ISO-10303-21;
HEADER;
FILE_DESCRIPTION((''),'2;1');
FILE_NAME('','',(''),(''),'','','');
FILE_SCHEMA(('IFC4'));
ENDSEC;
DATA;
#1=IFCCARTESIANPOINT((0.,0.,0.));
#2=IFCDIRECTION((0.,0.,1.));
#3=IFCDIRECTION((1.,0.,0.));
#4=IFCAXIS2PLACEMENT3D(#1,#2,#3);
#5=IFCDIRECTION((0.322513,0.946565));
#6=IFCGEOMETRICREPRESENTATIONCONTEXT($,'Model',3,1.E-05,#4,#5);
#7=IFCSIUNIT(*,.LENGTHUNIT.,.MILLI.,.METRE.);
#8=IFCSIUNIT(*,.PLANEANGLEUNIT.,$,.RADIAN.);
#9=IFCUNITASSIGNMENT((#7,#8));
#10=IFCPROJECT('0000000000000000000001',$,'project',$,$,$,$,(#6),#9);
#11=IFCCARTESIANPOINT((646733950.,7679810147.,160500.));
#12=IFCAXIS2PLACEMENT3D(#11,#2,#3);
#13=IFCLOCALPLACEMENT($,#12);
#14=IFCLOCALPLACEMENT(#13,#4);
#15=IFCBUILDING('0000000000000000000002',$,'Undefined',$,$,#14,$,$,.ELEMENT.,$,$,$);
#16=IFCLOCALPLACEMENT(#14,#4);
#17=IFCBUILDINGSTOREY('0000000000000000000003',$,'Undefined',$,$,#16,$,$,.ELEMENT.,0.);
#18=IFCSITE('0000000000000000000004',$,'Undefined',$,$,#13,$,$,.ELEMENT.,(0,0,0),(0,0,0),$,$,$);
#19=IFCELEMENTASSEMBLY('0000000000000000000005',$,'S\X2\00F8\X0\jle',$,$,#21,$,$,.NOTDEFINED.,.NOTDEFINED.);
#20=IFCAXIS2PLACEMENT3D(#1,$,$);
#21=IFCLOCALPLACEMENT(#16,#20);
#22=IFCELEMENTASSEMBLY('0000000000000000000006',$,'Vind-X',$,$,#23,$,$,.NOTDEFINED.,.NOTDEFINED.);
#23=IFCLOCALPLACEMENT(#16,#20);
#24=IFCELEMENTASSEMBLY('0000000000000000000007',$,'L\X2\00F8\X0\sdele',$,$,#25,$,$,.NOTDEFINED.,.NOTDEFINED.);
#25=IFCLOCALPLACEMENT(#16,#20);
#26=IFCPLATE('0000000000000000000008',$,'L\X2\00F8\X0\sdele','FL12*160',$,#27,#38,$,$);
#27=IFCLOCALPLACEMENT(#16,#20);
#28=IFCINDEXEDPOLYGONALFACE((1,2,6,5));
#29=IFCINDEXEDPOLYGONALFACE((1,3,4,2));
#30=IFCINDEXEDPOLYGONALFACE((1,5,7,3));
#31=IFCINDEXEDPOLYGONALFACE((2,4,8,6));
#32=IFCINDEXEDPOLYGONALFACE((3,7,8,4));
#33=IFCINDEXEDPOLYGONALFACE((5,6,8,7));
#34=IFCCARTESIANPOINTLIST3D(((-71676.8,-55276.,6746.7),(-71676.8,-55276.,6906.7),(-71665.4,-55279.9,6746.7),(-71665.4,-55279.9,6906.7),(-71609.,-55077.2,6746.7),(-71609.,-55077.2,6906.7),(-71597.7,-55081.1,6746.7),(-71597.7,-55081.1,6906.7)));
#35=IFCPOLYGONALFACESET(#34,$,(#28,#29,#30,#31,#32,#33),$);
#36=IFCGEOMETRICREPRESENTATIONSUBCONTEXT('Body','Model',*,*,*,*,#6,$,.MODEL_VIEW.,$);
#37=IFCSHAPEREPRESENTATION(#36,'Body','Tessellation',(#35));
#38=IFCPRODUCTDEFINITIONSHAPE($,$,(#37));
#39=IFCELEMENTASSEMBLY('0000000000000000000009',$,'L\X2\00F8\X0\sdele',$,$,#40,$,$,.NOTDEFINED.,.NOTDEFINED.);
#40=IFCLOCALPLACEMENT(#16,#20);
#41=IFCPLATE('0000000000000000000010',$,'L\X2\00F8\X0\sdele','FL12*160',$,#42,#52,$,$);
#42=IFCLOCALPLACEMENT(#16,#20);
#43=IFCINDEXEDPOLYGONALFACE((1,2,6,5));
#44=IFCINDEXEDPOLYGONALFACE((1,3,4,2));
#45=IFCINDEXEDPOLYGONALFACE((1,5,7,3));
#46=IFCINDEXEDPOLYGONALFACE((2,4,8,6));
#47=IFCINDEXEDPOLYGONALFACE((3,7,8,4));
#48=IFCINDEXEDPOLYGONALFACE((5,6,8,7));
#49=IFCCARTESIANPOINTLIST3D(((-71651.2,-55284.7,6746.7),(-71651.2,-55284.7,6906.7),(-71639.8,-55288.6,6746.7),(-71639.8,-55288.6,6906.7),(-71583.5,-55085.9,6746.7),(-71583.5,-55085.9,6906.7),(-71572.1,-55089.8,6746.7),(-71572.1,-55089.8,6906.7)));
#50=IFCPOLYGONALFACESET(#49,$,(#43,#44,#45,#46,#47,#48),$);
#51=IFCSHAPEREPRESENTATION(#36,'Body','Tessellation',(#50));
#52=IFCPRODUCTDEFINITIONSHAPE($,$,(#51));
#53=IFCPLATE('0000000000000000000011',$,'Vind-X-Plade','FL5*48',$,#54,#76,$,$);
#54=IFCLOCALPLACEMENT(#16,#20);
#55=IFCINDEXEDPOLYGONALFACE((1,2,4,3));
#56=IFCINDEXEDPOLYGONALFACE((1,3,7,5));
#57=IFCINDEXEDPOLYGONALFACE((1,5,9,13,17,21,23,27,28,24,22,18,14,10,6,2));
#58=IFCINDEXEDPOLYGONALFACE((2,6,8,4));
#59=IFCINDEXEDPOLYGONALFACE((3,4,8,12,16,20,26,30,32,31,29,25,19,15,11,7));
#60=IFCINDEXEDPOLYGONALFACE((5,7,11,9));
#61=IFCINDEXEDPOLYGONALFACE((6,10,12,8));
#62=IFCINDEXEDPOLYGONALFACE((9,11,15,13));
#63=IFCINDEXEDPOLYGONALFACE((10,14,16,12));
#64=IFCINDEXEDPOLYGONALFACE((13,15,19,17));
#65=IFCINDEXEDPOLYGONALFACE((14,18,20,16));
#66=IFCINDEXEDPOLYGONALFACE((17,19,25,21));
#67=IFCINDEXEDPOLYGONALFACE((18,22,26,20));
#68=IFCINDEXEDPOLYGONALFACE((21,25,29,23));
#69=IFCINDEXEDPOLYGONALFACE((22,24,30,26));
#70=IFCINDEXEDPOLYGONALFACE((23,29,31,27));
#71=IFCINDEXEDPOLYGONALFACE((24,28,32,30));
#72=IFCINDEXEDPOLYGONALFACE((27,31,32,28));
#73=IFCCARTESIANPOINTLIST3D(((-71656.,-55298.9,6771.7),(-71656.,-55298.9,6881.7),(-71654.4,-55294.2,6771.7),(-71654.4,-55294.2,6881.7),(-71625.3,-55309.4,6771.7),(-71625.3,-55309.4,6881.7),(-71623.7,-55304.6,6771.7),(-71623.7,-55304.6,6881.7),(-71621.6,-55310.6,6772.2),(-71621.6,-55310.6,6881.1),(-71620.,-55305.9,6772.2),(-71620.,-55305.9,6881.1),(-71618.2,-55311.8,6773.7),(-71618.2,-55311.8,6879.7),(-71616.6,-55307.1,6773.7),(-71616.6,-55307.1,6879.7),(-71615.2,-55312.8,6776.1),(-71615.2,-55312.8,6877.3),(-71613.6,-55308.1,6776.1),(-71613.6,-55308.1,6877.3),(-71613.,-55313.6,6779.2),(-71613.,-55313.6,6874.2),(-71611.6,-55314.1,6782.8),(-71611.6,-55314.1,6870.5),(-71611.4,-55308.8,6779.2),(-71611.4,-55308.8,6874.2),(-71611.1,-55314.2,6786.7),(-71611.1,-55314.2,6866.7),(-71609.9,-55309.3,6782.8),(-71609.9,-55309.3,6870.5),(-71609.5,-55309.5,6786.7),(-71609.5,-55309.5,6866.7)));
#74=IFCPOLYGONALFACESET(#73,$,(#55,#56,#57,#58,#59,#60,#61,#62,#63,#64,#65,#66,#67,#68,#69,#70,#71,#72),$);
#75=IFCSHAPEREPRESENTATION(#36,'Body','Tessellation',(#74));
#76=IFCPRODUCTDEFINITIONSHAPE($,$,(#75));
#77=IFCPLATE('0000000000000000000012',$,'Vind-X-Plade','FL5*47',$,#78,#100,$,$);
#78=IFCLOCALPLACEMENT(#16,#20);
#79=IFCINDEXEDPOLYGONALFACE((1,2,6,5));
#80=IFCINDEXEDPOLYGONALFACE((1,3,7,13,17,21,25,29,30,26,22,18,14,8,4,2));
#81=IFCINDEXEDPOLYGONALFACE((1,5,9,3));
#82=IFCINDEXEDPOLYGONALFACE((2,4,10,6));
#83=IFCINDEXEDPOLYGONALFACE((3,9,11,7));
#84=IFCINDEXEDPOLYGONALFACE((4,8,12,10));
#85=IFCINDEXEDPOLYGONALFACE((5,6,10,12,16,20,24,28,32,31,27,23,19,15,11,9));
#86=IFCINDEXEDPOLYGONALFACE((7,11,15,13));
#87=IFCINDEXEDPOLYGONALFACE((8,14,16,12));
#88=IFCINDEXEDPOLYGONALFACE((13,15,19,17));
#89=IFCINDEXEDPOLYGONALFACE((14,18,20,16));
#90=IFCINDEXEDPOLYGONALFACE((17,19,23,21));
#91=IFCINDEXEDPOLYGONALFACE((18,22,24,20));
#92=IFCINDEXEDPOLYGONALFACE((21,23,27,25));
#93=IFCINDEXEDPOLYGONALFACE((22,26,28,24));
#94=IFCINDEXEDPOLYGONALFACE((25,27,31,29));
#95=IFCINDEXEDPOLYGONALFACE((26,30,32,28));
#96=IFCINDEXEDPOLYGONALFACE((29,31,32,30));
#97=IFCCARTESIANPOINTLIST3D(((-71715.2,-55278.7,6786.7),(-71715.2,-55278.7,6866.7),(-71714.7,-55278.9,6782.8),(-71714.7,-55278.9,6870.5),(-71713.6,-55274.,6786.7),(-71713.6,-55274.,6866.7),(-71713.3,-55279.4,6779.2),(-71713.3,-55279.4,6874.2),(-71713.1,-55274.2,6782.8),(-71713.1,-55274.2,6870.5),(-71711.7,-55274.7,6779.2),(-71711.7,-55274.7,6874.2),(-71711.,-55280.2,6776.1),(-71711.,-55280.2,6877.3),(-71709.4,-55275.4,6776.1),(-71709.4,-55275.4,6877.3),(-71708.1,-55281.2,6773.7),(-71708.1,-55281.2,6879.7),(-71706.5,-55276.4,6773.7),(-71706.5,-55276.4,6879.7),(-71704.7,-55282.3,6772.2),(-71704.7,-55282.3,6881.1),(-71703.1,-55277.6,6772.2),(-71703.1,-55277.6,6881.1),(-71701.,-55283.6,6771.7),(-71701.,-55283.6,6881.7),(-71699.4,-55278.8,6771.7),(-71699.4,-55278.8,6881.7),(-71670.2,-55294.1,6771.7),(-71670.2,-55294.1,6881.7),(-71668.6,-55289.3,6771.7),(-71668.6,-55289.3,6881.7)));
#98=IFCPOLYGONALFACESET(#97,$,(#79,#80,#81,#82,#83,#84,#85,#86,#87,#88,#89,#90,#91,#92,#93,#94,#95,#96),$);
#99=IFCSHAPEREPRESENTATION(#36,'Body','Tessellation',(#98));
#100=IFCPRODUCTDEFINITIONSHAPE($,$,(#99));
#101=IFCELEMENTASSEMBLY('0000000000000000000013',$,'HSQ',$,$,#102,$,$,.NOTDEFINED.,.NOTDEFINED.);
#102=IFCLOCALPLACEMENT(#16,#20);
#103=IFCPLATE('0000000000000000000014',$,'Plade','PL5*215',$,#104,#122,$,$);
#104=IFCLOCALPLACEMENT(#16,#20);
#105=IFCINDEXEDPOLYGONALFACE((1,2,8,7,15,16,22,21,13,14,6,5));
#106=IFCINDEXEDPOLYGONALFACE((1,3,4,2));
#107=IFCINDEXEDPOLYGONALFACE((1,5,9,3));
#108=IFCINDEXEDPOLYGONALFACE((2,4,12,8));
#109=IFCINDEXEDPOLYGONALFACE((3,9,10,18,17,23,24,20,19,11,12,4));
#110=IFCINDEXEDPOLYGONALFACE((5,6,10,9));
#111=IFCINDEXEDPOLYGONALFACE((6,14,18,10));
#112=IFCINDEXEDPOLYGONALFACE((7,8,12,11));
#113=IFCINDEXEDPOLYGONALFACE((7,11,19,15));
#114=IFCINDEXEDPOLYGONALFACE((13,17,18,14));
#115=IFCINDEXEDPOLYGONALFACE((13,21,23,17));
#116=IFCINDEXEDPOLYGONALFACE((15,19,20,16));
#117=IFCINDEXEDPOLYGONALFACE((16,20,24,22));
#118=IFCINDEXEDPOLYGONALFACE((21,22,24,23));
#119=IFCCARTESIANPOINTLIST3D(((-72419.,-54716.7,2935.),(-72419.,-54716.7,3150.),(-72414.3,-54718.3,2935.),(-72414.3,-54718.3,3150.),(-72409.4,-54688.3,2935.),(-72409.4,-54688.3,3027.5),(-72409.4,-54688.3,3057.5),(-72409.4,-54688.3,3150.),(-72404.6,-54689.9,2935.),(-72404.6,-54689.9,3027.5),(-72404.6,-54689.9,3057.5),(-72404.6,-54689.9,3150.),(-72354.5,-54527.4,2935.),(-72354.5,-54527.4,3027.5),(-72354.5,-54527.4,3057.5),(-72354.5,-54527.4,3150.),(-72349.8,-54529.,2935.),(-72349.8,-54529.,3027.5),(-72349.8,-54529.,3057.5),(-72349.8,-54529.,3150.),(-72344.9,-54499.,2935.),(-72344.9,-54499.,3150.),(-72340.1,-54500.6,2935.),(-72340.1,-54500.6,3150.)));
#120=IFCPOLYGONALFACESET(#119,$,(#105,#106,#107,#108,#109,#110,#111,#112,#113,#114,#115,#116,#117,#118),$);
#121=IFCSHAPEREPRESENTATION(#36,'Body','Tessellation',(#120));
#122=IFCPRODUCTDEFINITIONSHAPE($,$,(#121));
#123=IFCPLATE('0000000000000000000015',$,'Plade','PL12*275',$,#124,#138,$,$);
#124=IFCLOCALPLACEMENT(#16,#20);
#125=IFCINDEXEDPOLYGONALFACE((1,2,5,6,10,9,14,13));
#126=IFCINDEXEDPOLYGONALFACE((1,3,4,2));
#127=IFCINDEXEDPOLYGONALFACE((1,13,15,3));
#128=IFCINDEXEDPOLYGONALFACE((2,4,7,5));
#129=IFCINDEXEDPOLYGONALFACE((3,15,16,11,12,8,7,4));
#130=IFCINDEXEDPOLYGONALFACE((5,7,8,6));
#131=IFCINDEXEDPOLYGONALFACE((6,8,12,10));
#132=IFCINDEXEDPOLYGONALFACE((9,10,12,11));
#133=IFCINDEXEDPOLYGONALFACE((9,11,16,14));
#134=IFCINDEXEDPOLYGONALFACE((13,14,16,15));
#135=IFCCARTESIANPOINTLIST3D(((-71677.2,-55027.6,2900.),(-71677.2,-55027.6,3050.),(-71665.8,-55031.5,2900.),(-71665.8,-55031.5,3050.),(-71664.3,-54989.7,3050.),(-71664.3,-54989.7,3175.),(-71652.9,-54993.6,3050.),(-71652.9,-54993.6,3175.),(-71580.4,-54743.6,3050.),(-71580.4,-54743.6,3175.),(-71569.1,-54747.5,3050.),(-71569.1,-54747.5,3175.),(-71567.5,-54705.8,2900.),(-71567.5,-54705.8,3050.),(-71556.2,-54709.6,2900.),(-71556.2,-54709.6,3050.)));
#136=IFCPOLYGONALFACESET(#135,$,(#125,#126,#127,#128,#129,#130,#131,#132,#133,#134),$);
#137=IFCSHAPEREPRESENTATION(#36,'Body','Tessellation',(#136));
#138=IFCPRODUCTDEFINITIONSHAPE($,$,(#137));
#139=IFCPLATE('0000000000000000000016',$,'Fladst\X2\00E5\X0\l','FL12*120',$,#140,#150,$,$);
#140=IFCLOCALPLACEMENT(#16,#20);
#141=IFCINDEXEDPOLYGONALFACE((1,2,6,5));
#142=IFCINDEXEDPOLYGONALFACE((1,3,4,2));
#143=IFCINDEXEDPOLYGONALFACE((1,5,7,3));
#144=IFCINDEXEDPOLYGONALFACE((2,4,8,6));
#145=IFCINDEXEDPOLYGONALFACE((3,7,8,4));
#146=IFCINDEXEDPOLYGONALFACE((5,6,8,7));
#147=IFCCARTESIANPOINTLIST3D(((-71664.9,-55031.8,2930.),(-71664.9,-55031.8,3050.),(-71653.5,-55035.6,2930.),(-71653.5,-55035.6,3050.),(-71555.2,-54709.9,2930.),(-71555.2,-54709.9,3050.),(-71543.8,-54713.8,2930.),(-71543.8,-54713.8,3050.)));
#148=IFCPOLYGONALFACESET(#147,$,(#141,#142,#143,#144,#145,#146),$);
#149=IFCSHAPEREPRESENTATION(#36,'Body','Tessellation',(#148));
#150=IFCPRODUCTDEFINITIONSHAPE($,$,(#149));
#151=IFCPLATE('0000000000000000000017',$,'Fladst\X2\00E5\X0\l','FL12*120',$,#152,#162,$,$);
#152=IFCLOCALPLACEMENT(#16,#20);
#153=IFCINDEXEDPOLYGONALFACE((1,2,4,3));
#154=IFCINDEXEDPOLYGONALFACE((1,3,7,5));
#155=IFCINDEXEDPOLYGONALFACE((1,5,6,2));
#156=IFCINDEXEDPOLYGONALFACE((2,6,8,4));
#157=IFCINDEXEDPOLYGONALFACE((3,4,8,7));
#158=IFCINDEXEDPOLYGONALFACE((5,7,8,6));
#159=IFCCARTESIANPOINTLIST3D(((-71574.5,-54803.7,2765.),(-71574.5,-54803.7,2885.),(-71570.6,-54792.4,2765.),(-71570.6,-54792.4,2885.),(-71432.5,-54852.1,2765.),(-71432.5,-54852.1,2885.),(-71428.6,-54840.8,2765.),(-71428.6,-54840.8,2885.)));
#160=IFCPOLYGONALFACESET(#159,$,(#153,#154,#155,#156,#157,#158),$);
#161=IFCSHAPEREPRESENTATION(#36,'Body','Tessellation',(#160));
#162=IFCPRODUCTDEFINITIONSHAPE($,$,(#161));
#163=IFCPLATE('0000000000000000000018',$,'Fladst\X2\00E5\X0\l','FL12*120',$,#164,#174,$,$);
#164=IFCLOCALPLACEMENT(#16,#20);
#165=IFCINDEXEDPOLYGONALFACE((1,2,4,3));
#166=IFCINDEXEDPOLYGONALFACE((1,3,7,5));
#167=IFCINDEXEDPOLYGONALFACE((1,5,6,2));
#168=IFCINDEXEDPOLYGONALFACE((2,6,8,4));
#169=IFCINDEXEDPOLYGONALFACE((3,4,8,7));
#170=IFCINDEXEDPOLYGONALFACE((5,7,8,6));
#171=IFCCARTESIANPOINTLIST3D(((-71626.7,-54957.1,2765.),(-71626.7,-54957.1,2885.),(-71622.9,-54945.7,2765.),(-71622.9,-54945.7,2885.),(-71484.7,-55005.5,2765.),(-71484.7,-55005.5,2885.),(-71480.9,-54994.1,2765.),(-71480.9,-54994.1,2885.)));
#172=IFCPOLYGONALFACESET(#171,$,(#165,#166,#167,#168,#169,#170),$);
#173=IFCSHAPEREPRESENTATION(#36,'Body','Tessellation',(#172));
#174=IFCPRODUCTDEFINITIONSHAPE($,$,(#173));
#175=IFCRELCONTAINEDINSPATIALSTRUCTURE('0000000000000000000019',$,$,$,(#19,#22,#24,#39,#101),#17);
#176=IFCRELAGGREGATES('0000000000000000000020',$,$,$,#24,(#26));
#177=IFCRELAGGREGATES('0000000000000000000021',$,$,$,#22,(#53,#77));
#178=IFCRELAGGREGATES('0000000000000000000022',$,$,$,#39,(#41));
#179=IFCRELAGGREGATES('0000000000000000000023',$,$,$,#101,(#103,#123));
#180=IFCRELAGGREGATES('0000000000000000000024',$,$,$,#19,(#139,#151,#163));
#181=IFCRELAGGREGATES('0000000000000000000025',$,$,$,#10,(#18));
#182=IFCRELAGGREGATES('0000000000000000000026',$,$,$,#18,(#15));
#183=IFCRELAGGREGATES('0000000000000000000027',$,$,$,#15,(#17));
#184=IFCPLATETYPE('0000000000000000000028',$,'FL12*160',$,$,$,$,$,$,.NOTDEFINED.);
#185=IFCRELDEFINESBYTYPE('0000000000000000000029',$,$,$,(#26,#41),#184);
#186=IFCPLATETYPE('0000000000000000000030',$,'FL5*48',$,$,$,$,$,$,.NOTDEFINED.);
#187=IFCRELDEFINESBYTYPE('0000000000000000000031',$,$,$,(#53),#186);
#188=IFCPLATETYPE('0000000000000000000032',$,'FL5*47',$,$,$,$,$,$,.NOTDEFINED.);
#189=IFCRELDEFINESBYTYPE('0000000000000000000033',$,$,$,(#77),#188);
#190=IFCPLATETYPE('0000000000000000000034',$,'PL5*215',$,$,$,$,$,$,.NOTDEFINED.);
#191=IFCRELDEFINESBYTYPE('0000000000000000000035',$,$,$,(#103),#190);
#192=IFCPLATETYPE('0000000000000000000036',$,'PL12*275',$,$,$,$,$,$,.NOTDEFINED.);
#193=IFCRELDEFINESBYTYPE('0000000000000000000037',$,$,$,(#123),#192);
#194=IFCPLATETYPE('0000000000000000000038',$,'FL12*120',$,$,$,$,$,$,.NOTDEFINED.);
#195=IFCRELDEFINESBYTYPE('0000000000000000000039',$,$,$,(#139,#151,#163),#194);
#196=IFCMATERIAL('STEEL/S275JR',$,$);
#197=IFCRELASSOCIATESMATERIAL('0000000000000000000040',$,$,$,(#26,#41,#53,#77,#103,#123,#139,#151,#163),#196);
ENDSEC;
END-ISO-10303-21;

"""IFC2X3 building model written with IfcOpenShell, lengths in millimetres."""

from ifc_helpers import new_model, si_unit, direction, frame, frame_2d, origin_with_axes, place, context, subcontext, project, spatial, polyline, circle_curve, parameter, trimmed, segment, composite_curve, outline, extrude, material, type_object, element, aggregate, save


model = new_model("IFC2X3")

# Units and contexts
model_context = context("Model", 3, precision=1e-05, world=origin_with_axes(), true_north=direction((0.322513, 0.946565)))
body_context = subcontext(model_context, "Body", "Model", "MODEL_VIEW")
ifc_project = project(units=[si_unit("LENGTHUNIT", "METRE", prefix="MILLI"), si_unit("PLANEANGLEUNIT", "RADIAN")], contexts=[model_context])

# Site, building, storey
site_placement = place(None, frame((646733950.0, 7679810147.0, 160500.0), z_axis=(0.0, 0.0, 1.0), x_axis=(1.0, 0.0, 0.0)))
site = spatial("IfcSite", under=ifc_project, at=site_placement, Name="Undefined", CompositionType="ELEMENT", RefLatitude=(0, 0, 0), RefLongitude=(0, 0, 0))
building_placement = place(site_placement, origin_with_axes())
building = spatial("IfcBuilding", under=site, at=building_placement, Name="Undefined", CompositionType="ELEMENT")
storey_placement = place(building_placement, origin_with_axes())
storey = spatial("IfcBuildingStorey", under=building, at=storey_placement, Name="Undefined", CompositionType="ELEMENT", Elevation=0.0)

# Element assembly
assembly_1_placement = place(storey_placement, origin_with_axes())
assembly_1 = element("IfcElementAssembly", 1, at=assembly_1_placement, inside=storey, Name="Søjle", AssemblyPlace="NOTDEFINED", PredefinedType="NOTDEFINED")

# Element assembly
assembly_2_placement = place(storey_placement, origin_with_axes())
assembly_2 = element("IfcElementAssembly", 2, at=assembly_2_placement, inside=storey, Name="Vind-X", AssemblyPlace="NOTDEFINED", PredefinedType="NOTDEFINED")

# Shared definitions
ifc_material_1 = material(Name="STEEL/S275JR")

# Element assemblies, plates
assembly_3_placement = place(storey_placement, origin_with_axes())
assembly_3 = element("IfcElementAssembly", 3, at=assembly_3_placement, inside=storey, Name="Løsdele", AssemblyPlace="NOTDEFINED", PredefinedType="NOTDEFINED")
plate_type_1 = type_object("IfcPlateType", Name="FL12*160", PredefinedType="NOTDEFINED")
plate_1_placement = place(assembly_3_placement, frame((-71603.4, -55079.1, 6826.7), z_axis=(-0.946565, 0.322513, 0.0), x_axis=(-0.322513, -0.946565, 0.0)))
plate_1 = element("IfcPlate", 4, at=plate_1_placement, type_object=plate_type_1, material=ifc_material_1, Name="Løsdele", Description="FL12*160", context=body_context, shape_type="SweptSolid", body=[
    extrude(outline(polyline([(0.0, -80.0), (0.0, 80.0), (210.0, 80.0), (210.0, -80.0), (0.0, -80.0)])), frame((0.0, 0.0, -6.0), z_axis=(0.0, 0.0, 1.0), x_axis=(1.0, 0.0, 0.0)), (0.0, 0.0, 1.0), 12.0),
])
aggregate(assembly_3, [plate_1])
assembly_4_placement = place(storey_placement, origin_with_axes())
assembly_4 = element("IfcElementAssembly", 5, at=assembly_4_placement, inside=storey, Name="Løsdele", AssemblyPlace="NOTDEFINED", PredefinedType="NOTDEFINED")
plate_2_placement = place(assembly_4_placement, frame((-71577.8, -55087.9, 6826.7), z_axis=(-0.946565, 0.322513, 0.0), x_axis=(-0.322513, -0.946565, 0.0)))
plate_2 = element("IfcPlate", 6, at=plate_2_placement, type_object=plate_type_1, material=ifc_material_1, Name="Løsdele", Description="FL12*160", context=body_context, shape_type="SweptSolid", body=[
    extrude(outline(polyline([(0.0, -80.0), (0.0, 80.0), (210.0, 80.0), (210.0, -80.0), (0.0, -80.0)])), frame((0.0, 0.0, -6.0), z_axis=(0.0, 0.0, 1.0), x_axis=(1.0, 0.0, 0.0)), (0.0, 0.0, 1.0), 12.0),
])

# Plates
plate_type_2 = type_object("IfcPlateType", Name="FL5*48", PredefinedType="NOTDEFINED")
plate_3_placement = place(assembly_2_placement, frame((-71610.3, -55311.9, 6881.7), z_axis=(-0.322513, -0.946565, 0.0), x_axis=(-0.946565, 0.322513, 0.0)))
plate_3 = element("IfcPlate", 7, at=plate_3_placement, type_object=plate_type_2, material=ifc_material_1, Name="Vind-X-Plade", Description="FL5*48", context=body_context, shape_type="SweptSolid", body=[
    extrude(outline(composite_curve([segment(trimmed(circle_curve(frame_2d((15.0, 15.0), x_axis=(-1.0, 0.0)), 15.0), [parameter(0.0)], [parameter(1.570796)], True, "PARAMETER"), True, "CONTINUOUS"), segment(polyline([(15.0, 0.0), (47.5, 0.0), (47.5, 110.0), (15.0, 110.0)]), True, "CONTINUOUS"), segment(trimmed(circle_curve(frame_2d((15.0, 95.0), x_axis=(0.0, 1.0)), 15.0), [parameter(0.0)], [parameter(1.570796)], True, "PARAMETER"), True, "CONTINUOUS"), segment(polyline([(0.0, 95.0), (0.0, 15.0)]), True, "CONTINUOUS")], self_intersect=True)), frame((0.0, 0.0, -2.5), z_axis=(0.0, 0.0, 1.0), x_axis=(1.0, 0.0, 0.0)), (0.0, 0.0, 1.0), 5.0),
])
plate_type_3 = type_object("IfcPlateType", Name="FL5*47", PredefinedType="NOTDEFINED")
plate_4_placement = place(assembly_2_placement, frame((-71669.4, -55291.7, 6881.7), z_axis=(-0.322513, -0.946565, 0.0), x_axis=(-0.946565, 0.322513, 0.0)))
plate_4 = element("IfcPlate", 8, at=plate_4_placement, type_object=plate_type_3, material=ifc_material_1, Name="Vind-X-Plade", Description="FL5*47", context=body_context, shape_type="SweptSolid", body=[
    extrude(outline(composite_curve([segment(polyline([(0.0, 0.0), (32.5, 0.0)]), True, "CONTINUOUS"), segment(trimmed(circle_curve(frame_2d((32.5, 15.0), x_axis=(0.0, -1.0)), 15.0), [parameter(0.0)], [parameter(1.570796)], True, "PARAMETER"), True, "CONTINUOUS"), segment(polyline([(47.5, 15.0), (47.5, 95.0)]), True, "CONTINUOUS"), segment(trimmed(circle_curve(frame_2d((32.5, 95.0), x_axis=(1.0, 0.0)), 15.0), [parameter(0.0)], [parameter(1.570796)], True, "PARAMETER"), True, "CONTINUOUS"), segment(polyline([(32.5, 110.0), (0.0, 110.0), (0.0, 0.0)]), True, "CONTINUOUS")], self_intersect=True)), frame((0.0, 0.0, -2.5), z_axis=(0.0, 0.0, 1.0), x_axis=(1.0, 0.0, 0.0)), (0.0, 0.0, 1.0), 5.0),
])
aggregate(assembly_2, [plate_3, plate_4])

# Element assembly, plates
assembly_5_placement = place(storey_placement, origin_with_axes())
assembly_5 = element("IfcElementAssembly", 9, at=assembly_5_placement, inside=storey, Name="HSQ", AssemblyPlace="NOTDEFINED", PredefinedType="NOTDEFINED")
plate_type_4 = type_object("IfcPlateType", Name="PL5*215", PredefinedType="NOTDEFINED")
plate_5_placement = place(assembly_5_placement, frame((-72416.7, -54717.5, 3150.0), z_axis=(0.946565, -0.322513, 0.0), x_axis=(0.0, 0.0, -1.0)))
plate_5 = element("IfcPlate", 10, at=plate_5_placement, type_object=plate_type_4, material=ifc_material_1, Name="Plade", Description="PL5*215", context=body_context, shape_type="SweptSolid", body=[
    extrude(outline(polyline([(0.0, 0.0), (215.0, 0.0), (215.0, 30.0), (122.5, 30.0), (122.5, 200.0), (215.0, 200.0), (215.0, 230.0), (0.0, 230.0), (0.0, 200.0), (92.5, 200.0), (92.5, 30.0), (0.0, 30.0), (0.0, 0.0)])), frame((0.0, 0.0, -2.5), z_axis=(0.0, 0.0, 1.0), x_axis=(1.0, 0.0, 0.0)), (0.0, 0.0, 1.0), 5.0),
])
plate_type_5 = type_object("IfcPlateType", Name="PL12*275", PredefinedType="NOTDEFINED")
plate_6_placement = place(assembly_5_placement, frame((-71561.8, -54707.7, 3175.0), z_axis=(0.946565, -0.322513, 0.0), x_axis=(-0.322513, -0.946565, 0.0)))
plate_6 = element("IfcPlate", 11, at=plate_6_placement, type_object=plate_type_5, material=ifc_material_1, Name="Plade", Description="PL12*275", context=body_context, shape_type="SweptSolid", body=[
    extrude(outline(polyline([(0.0, 125.0), (40.0, 125.0), (40.0, 0.0), (300.0, 0.0), (300.0, 125.0), (340.0, 125.0), (340.0, 275.0), (0.0, 275.0), (0.0, 125.0)])), frame((0.0, 0.0, -6.0), z_axis=(0.0, 0.0, 1.0), x_axis=(1.0, 0.0, 0.0)), (0.0, 0.0, 1.0), 12.0),
])

# Plates
plate_type_6 = type_object("IfcPlateType", Name="FL12*120", PredefinedType="NOTDEFINED")
plate_7_placement = place(assembly_1_placement, frame((-71549.5, -54711.9, 3050.0), z_axis=(0.946565, -0.322513, 0.0), x_axis=(-0.322513, -0.946565, 0.0)))
plate_7 = element("IfcPlate", 12, at=plate_7_placement, type_object=plate_type_6, material=ifc_material_1, Name="Fladstål", Description="FL12*120", context=body_context, shape_type="SweptSolid", body=[
    extrude(outline(polyline([(0.0, 0.0), (340.0, 0.0), (340.0, 120.0), (0.0, 120.0), (0.0, 0.0)])), frame((0.0, 0.0, -6.0), z_axis=(0.0, 0.0, 1.0), x_axis=(1.0, 0.0, 0.0)), (0.0, 0.0, 1.0), 12.0),
])
plate_8_placement = place(assembly_1_placement, frame((-71430.6, -54846.4, 2885.0), z_axis=(-0.322513, -0.946565, 0.0), x_axis=(-0.946565, 0.322513, 0.0)))
plate_8 = element("IfcPlate", 13, at=plate_8_placement, type_object=plate_type_6, material=ifc_material_1, Name="Fladstål", Description="FL12*120", context=body_context, shape_type="SweptSolid", body=[
    extrude(outline(polyline([(0.0, 0.0), (150.0, 0.0), (150.0, 120.0), (0.0, 120.0), (0.0, 0.0)])), frame((0.0, 0.0, -6.0), z_axis=(0.0, 0.0, 1.0), x_axis=(1.0, 0.0, 0.0)), (0.0, 0.0, 1.0), 12.0),
])
plate_9_placement = place(assembly_1_placement, frame((-71482.8, -54999.8, 2885.0), z_axis=(-0.322513, -0.946565, 0.0), x_axis=(-0.946565, 0.322513, 0.0)))
plate_9 = element("IfcPlate", 14, at=plate_9_placement, type_object=plate_type_6, material=ifc_material_1, Name="Fladstål", Description="FL12*120", context=body_context, shape_type="SweptSolid", body=[
    extrude(outline(polyline([(0.0, 0.0), (150.0, 0.0), (150.0, 120.0), (0.0, 120.0), (0.0, 0.0)])), frame((0.0, 0.0, -6.0), z_axis=(0.0, 0.0, 1.0), x_axis=(1.0, 0.0, 0.0)), (0.0, 0.0, 1.0), 12.0),
])

aggregate(assembly_4, [plate_2])

aggregate(assembly_5, [plate_5, plate_6])
aggregate(assembly_1, [plate_7, plate_8, plate_9])

save(model, "model.ifc")
